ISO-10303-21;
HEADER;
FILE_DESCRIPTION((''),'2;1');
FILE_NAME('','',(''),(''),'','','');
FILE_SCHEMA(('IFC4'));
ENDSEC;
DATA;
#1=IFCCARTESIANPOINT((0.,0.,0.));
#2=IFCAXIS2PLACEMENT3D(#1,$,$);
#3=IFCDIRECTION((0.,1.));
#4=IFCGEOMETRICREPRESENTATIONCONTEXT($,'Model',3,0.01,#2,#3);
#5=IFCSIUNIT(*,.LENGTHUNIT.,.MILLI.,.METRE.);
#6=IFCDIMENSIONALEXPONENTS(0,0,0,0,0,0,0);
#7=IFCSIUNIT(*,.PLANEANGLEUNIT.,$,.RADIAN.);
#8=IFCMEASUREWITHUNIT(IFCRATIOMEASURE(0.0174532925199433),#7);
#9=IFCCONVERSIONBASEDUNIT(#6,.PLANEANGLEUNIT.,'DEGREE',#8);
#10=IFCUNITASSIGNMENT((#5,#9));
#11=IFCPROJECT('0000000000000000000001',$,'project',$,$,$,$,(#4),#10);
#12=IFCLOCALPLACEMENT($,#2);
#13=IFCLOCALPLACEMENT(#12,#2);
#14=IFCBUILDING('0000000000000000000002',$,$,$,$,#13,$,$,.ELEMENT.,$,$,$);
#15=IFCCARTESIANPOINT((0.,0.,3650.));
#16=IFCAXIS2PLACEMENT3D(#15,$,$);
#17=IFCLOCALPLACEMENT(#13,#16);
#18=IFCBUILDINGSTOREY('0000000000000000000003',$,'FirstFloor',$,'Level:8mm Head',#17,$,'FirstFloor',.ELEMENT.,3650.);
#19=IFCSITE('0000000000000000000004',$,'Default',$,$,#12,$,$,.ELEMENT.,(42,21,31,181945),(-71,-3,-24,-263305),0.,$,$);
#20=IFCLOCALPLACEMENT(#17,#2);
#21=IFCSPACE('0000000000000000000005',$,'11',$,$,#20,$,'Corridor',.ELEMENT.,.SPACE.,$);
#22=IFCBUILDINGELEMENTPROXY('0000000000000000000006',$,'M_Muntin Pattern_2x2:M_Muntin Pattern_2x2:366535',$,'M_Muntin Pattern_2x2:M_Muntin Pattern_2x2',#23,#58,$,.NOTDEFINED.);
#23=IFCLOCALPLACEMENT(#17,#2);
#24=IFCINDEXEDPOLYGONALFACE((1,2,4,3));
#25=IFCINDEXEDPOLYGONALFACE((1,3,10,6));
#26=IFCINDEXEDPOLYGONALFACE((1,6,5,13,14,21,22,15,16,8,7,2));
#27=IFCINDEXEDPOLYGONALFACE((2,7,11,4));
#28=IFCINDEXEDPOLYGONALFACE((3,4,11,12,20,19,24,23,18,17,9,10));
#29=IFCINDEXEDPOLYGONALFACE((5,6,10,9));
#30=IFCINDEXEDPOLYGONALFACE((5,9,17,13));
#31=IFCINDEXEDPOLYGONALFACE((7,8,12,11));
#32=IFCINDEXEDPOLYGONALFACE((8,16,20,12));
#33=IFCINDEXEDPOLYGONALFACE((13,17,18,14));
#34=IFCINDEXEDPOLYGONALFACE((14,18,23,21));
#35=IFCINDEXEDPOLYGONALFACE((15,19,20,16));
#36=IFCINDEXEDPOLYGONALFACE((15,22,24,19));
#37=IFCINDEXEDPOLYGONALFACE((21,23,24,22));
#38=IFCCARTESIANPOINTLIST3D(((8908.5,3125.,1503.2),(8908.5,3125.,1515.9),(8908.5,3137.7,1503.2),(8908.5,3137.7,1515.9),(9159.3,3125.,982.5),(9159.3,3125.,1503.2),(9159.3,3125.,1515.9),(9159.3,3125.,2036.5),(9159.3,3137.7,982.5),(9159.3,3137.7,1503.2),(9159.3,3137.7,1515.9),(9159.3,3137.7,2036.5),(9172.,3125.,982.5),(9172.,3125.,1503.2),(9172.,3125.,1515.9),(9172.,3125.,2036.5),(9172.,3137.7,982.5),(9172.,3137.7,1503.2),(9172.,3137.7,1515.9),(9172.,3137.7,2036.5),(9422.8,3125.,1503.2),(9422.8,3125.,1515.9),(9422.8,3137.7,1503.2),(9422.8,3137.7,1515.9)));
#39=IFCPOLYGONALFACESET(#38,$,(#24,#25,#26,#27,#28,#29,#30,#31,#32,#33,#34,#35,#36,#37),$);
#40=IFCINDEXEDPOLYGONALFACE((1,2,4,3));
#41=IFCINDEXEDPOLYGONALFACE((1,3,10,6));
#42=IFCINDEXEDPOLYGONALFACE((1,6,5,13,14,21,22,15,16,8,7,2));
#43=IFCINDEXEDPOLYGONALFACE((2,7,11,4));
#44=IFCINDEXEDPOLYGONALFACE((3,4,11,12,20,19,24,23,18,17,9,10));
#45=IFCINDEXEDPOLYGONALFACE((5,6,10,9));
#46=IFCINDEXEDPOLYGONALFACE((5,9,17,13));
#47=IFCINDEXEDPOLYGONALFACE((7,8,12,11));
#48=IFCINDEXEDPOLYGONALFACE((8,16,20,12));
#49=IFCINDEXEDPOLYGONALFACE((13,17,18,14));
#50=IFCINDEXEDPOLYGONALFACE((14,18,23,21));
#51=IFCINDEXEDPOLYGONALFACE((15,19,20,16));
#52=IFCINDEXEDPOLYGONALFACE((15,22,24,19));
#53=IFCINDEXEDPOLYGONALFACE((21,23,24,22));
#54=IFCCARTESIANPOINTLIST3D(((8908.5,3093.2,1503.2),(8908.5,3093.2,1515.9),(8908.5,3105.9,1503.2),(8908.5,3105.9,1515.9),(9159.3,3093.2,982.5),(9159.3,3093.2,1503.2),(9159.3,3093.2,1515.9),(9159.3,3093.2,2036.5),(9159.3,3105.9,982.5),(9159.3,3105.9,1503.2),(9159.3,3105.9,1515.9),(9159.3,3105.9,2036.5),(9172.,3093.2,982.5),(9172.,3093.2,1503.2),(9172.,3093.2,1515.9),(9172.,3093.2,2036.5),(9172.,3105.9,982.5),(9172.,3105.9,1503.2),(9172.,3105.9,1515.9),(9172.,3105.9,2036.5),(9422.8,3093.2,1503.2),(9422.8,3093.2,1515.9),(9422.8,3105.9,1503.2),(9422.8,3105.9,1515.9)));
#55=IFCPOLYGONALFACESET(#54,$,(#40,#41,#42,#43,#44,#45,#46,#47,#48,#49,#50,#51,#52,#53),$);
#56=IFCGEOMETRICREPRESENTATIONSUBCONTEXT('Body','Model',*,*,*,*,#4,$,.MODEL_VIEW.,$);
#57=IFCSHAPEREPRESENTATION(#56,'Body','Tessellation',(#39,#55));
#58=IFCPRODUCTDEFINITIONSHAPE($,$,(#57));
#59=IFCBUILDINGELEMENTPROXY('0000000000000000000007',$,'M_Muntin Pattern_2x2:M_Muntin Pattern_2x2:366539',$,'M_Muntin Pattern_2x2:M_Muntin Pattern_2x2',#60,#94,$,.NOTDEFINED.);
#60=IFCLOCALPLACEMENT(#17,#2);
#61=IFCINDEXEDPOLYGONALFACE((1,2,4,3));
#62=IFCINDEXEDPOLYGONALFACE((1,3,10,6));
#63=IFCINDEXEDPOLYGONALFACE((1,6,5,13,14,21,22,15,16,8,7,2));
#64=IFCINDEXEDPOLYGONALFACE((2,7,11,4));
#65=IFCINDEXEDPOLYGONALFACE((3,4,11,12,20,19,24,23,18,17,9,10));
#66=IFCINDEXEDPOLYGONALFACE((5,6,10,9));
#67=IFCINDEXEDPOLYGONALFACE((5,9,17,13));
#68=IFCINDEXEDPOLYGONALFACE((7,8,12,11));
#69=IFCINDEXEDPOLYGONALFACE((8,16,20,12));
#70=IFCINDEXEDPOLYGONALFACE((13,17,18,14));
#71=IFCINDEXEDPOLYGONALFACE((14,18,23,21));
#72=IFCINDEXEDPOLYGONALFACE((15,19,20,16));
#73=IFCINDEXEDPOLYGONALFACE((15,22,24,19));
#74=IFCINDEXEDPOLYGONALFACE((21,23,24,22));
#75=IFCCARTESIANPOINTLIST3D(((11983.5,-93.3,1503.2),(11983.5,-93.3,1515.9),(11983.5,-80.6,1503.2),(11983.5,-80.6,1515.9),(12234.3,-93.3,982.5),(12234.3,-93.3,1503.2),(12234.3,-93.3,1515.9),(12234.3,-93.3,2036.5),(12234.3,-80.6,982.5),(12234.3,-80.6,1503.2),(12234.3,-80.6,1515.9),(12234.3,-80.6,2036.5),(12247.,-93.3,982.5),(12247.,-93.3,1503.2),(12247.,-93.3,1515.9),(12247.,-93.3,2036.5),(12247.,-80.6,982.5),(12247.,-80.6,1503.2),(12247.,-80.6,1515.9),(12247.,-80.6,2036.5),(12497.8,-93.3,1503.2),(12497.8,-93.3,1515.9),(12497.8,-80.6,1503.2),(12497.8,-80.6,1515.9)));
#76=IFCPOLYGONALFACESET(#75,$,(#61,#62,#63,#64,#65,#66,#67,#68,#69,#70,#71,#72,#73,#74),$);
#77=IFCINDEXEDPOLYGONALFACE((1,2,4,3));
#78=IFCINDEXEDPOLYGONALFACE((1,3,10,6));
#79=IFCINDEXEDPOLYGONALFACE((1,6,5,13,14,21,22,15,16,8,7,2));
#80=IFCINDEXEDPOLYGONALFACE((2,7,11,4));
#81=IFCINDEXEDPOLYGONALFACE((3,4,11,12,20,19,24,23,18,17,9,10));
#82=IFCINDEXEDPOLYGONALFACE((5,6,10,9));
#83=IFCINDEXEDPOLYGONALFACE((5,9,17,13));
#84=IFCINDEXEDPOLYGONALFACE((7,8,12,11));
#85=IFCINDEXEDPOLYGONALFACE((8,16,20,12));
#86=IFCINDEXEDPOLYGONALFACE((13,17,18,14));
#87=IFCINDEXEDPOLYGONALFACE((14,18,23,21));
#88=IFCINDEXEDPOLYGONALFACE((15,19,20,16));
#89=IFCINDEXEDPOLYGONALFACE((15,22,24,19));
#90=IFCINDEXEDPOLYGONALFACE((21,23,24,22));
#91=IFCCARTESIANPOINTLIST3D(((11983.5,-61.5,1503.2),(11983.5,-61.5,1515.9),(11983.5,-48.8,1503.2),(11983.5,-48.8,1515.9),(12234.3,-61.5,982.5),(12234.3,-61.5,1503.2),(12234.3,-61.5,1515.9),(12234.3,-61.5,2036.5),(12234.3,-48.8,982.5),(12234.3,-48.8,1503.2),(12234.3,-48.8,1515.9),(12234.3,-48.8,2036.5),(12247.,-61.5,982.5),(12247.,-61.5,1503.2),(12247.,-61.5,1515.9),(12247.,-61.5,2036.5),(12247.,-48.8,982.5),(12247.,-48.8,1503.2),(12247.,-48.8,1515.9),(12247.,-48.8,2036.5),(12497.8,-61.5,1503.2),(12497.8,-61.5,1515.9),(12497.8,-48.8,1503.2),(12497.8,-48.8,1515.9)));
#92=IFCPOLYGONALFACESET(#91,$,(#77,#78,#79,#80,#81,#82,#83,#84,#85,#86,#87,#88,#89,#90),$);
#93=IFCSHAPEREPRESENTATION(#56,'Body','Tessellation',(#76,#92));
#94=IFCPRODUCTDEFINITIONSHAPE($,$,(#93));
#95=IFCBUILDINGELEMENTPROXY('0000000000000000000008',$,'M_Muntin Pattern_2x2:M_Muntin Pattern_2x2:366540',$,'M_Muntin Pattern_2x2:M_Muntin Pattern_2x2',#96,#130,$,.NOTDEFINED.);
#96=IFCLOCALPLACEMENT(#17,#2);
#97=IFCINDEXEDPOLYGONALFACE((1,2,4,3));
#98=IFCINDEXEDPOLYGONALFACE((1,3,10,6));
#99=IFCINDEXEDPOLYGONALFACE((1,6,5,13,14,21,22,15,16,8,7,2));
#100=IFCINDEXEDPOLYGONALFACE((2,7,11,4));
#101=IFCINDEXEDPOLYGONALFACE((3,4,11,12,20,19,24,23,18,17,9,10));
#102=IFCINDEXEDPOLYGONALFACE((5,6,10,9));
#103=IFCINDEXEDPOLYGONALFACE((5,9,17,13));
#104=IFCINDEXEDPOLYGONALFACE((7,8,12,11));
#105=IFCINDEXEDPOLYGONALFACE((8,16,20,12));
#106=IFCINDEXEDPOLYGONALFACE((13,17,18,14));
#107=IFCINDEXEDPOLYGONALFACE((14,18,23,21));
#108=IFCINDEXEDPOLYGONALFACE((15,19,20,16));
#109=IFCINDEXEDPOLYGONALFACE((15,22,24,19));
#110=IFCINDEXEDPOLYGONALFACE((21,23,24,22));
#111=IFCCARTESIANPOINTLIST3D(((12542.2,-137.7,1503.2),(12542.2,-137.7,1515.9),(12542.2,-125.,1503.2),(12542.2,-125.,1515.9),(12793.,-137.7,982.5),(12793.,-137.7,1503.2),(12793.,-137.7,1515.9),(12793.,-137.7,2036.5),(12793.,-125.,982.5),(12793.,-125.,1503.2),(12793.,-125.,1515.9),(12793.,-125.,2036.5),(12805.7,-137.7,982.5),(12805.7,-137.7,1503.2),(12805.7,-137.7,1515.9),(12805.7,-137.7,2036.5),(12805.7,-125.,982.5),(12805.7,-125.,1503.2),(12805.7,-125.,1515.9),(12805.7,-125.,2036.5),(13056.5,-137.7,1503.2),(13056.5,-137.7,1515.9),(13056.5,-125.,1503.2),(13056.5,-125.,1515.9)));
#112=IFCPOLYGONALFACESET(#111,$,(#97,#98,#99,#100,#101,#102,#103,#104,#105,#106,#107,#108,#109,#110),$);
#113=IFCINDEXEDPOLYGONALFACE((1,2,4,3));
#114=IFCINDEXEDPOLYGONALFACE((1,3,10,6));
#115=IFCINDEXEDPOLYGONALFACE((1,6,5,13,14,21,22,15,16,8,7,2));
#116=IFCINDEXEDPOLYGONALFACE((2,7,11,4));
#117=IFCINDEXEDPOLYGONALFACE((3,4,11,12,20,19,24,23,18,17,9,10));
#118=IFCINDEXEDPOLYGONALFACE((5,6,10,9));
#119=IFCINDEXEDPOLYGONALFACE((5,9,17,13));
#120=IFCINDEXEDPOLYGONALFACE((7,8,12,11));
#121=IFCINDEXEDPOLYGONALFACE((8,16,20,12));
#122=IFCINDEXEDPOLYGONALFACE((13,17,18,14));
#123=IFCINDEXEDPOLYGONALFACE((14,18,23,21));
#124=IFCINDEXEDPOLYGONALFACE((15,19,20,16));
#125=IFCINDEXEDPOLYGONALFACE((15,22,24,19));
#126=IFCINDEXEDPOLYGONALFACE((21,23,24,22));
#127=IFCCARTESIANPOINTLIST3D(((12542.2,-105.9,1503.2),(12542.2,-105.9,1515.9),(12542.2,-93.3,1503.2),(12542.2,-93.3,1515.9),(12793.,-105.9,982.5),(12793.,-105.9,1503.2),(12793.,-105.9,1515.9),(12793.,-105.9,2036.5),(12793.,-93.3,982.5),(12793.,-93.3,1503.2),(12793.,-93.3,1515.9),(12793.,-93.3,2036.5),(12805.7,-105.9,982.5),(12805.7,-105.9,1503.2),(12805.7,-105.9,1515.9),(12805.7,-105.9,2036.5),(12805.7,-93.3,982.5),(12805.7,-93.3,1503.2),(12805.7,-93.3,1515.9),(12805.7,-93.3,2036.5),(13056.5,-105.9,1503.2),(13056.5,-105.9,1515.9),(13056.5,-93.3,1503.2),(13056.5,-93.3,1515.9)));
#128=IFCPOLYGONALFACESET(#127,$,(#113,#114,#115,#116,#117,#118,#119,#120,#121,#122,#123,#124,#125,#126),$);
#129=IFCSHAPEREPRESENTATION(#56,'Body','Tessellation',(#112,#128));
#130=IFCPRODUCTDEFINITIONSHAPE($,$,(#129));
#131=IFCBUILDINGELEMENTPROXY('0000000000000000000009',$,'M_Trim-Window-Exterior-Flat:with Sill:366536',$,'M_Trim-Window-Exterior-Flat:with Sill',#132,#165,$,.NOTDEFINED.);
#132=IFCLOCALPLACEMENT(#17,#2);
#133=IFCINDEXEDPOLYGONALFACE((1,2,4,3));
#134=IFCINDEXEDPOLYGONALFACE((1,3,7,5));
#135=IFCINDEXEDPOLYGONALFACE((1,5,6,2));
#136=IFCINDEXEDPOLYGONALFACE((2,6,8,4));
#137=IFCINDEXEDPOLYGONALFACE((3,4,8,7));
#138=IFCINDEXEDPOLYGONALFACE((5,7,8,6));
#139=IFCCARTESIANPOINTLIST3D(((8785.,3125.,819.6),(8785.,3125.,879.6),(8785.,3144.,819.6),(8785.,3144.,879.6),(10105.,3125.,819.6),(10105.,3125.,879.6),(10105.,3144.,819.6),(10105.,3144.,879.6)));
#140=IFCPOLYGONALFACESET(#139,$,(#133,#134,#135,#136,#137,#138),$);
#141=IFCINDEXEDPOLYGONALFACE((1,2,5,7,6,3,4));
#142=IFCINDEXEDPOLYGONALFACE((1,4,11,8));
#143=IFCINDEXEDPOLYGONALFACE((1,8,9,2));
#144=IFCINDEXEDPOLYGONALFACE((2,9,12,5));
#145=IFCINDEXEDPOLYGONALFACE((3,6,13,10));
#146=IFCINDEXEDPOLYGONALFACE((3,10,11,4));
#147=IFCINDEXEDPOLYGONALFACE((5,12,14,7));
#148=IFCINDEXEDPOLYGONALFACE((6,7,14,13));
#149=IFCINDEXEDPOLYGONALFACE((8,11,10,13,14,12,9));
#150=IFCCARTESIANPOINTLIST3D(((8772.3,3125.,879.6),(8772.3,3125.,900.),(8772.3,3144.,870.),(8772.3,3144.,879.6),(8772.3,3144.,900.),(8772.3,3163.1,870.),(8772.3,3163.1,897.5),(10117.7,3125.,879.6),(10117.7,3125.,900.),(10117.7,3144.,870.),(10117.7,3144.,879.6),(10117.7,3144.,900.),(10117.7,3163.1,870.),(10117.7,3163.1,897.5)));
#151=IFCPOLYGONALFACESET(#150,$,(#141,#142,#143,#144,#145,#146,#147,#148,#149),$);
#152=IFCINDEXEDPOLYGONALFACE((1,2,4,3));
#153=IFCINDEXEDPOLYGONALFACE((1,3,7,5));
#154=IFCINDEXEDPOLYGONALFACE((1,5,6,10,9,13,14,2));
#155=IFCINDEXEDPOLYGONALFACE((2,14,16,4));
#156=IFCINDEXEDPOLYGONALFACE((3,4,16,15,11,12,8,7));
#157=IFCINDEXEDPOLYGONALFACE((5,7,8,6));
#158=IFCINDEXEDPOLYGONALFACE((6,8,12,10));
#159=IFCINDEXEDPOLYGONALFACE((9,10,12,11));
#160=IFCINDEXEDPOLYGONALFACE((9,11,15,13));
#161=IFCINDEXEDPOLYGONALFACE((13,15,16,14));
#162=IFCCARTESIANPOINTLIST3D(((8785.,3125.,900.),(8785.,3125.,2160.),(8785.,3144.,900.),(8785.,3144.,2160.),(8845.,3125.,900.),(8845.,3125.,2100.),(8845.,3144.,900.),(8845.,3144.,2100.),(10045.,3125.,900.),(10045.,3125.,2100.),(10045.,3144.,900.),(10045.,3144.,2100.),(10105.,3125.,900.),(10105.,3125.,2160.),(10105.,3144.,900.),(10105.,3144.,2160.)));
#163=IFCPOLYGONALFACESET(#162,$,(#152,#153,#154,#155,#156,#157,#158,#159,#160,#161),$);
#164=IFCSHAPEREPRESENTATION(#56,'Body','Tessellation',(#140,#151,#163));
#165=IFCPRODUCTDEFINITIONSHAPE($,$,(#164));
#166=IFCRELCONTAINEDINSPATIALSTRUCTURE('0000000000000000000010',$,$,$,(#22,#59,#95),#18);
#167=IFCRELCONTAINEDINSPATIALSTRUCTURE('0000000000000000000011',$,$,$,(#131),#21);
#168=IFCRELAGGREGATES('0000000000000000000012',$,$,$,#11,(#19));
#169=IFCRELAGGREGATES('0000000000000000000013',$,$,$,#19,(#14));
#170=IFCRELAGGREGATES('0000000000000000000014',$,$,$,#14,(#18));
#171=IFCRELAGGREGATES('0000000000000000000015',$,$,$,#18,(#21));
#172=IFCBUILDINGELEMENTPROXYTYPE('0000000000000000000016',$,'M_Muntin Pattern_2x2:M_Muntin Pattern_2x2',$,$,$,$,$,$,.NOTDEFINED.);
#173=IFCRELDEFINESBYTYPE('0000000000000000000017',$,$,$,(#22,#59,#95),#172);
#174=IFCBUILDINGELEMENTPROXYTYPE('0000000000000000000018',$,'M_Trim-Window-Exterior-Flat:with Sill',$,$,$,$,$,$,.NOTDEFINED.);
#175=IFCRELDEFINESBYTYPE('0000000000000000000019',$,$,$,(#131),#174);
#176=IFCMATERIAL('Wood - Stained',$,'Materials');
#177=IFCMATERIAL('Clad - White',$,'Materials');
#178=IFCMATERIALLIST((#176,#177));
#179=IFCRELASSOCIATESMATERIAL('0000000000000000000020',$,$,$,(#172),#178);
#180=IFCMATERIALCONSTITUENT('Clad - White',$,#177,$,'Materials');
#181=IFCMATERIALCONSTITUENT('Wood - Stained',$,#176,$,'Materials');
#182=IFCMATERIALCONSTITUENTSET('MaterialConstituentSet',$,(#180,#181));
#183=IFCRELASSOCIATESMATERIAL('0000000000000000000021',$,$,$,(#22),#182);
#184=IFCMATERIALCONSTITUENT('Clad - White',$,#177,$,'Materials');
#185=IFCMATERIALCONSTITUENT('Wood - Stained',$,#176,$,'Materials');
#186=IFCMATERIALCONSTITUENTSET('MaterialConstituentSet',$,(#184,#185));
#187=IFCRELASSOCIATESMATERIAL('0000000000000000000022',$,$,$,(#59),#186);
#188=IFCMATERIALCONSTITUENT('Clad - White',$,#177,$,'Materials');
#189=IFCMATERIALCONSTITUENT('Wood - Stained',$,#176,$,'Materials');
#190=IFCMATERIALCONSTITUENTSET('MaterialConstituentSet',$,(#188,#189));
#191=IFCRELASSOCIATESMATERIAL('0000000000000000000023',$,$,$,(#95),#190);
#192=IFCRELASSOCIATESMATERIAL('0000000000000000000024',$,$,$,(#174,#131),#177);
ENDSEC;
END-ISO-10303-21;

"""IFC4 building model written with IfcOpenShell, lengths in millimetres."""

from ifc_helpers import new_model, entity, si_unit, converted_unit, direction, frame, frame_2d, origin, place, context, subcontext, project, spatial, polyline, rectangle, outline, extrude, source, transform, mapped, material, material_list, constituent, constituent_set, type_object, type_shapes, element, save


model = new_model("IFC4")

# Units and contexts
model_context = context("Model", 3, precision=0.01, world=origin(), true_north=direction((0.0, 1.0)))
body_context = subcontext(model_context, "Body", "Model", "MODEL_VIEW")
ifc_project = project(units=[si_unit("LENGTHUNIT", "METRE", prefix="MILLI"), converted_unit("PLANEANGLEUNIT", "DEGREE", entity("IfcRatioMeasure", 0.0174532925199433), si_unit("PLANEANGLEUNIT", "RADIAN"), dimensions=[0, 0, 0, 0, 0, 0, 0])], contexts=[model_context])

# Site, building, storey
site_placement = place(None, origin())
site = spatial("IfcSite", under=ifc_project, at=site_placement, Name="Default", CompositionType="ELEMENT", RefLatitude=(42, 21, 31, 181945), RefLongitude=(-71, -3, -24, -263305), RefElevation=0.0)
building_placement = place(site_placement, origin())
building = spatial("IfcBuilding", under=site, at=building_placement, CompositionType="ELEMENT")
storey_placement = place(building_placement, frame((0.0, 0.0, 3650.0)))
storey = spatial("IfcBuildingStorey", under=building, at=storey_placement, Name="FirstFloor", ObjectType="Level:8mm Head", LongName="FirstFloor", CompositionType="ELEMENT", Elevation=3650.0)

# Building element proxies
ifc_material_1 = material(Name="Clad - White", Category="Materials")
ifc_material_2 = material(Name="Wood - Stained", Category="Materials")
ifc_material_list_1 = material_list([ifc_material_2, ifc_material_1])
building_element_proxy_type_1 = type_object("IfcBuildingElementProxyType", Name="M_Muntin Pattern_2x2:M_Muntin Pattern_2x2", PredefinedType="NOTDEFINED", material=ifc_material_list_1)
shared_shape_1 = source(origin(), body_context, "Body", "SweptSolid", [
    extrude(outline(polyline([(6.4, -6.4), (527.0, -6.4), (527.0, 6.3), (6.4, 6.3), (6.4, 257.1), (-6.3, 257.1), (-6.3, 6.3), (-527.0, 6.3), (-527.0, -6.4), (-6.3, -6.4), (-6.3, -257.1), (6.4, -257.1), (6.4, -6.4)])), frame((0.0, 9.5, 527.0), z_axis=(0.0, 1.0, 0.0), x_axis=(0.0, 0.0, 1.0)), (0.0, 0.0, 1.0), 12.7),
    extrude(outline(polyline([(6.4, -6.4), (527.0, -6.4), (527.0, 6.3), (6.4, 6.3), (6.4, 257.1), (-6.3, 257.1), (-6.3, 6.3), (-527.0, 6.3), (-527.0, -6.4), (-6.3, -6.4), (-6.3, -257.1), (6.4, -257.1), (6.4, -6.4)])), frame((0.0, -22.2, 527.0), z_axis=(0.0, 1.0, 0.0), x_axis=(0.0, 0.0, 1.0)), (0.0, 0.0, 1.0), 12.7),
])
type_shapes(building_element_proxy_type_1, [shared_shape_1])
ifc_constituent_1 = constituent(ifc_material_1, Name="Clad - White", Category="Materials")
ifc_constituent_2 = constituent(ifc_material_2, Name="Wood - Stained", Category="Materials")
ifc_constituent_set_1 = constituent_set(constituents=[ifc_constituent_1, ifc_constituent_2], Name="MaterialConstituentSet")
proxy_1_placement = place(storey_placement, frame((9165.6, 3115.5, 982.5)))
element("IfcBuildingElementProxy", 1, at=proxy_1_placement, inside=storey, type_object=building_element_proxy_type_1, material=ifc_constituent_set_1, Name="M_Muntin Pattern_2x2:M_Muntin Pattern_2x2:366535", ObjectType="M_Muntin Pattern_2x2:M_Muntin Pattern_2x2", PredefinedType="NOTDEFINED", context=body_context, shape_type="MappedRepresentation", body=[
    mapped(shared_shape_1, transform((0.0, 0.0, 0.0), scale=1.0)),
])
ifc_constituent_3 = constituent(ifc_material_1, Name="Clad - White", Category="Materials")
ifc_constituent_4 = constituent(ifc_material_2, Name="Wood - Stained", Category="Materials")
ifc_constituent_set_2 = constituent_set(constituents=[ifc_constituent_3, ifc_constituent_4], Name="MaterialConstituentSet")
proxy_2_placement = place(storey_placement, frame((12240.6, -71.0, 982.5), z_axis=(0.0, 0.0, 1.0), x_axis=(-1.0, 0.0, 0.0)))
element("IfcBuildingElementProxy", 2, at=proxy_2_placement, inside=storey, type_object=building_element_proxy_type_1, material=ifc_constituent_set_2, Name="M_Muntin Pattern_2x2:M_Muntin Pattern_2x2:366539", ObjectType="M_Muntin Pattern_2x2:M_Muntin Pattern_2x2", PredefinedType="NOTDEFINED", context=body_context, shape_type="MappedRepresentation", body=[
    mapped(shared_shape_1, transform((0.0, 0.0, 0.0), scale=1.0)),
])
ifc_constituent_5 = constituent(ifc_material_1, Name="Clad - White", Category="Materials")
ifc_constituent_6 = constituent(ifc_material_2, Name="Wood - Stained", Category="Materials")
ifc_constituent_set_3 = constituent_set(constituents=[ifc_constituent_5, ifc_constituent_6], Name="MaterialConstituentSet")
proxy_3_placement = place(storey_placement, frame((12799.4, -115.5, 982.5), z_axis=(0.0, 0.0, 1.0), x_axis=(-1.0, 0.0, 0.0)))
element("IfcBuildingElementProxy", 3, at=proxy_3_placement, inside=storey, type_object=building_element_proxy_type_1, material=ifc_constituent_set_3, Name="M_Muntin Pattern_2x2:M_Muntin Pattern_2x2:366540", ObjectType="M_Muntin Pattern_2x2:M_Muntin Pattern_2x2", PredefinedType="NOTDEFINED", context=body_context, shape_type="MappedRepresentation", body=[
    mapped(shared_shape_1, transform((0.0, 0.0, 0.0), scale=1.0)),
])

# Shared definitions
space_1_placement = place(storey_placement, origin())
space_1 = spatial("IfcSpace", under=storey, at=space_1_placement, Name="11", LongName="Corridor", CompositionType="ELEMENT", PredefinedType="SPACE")

# Building element proxy
building_element_proxy_type_2 = type_object("IfcBuildingElementProxyType", Name="M_Trim-Window-Exterior-Flat:with Sill", PredefinedType="NOTDEFINED", material=ifc_material_1)
shared_shape_2 = source(origin(), body_context, "Body", "SweptSolid", [
    extrude(rectangle(XDim=1320.0, YDim=60.0, at=frame_2d((0.0, 0.0), x_axis=(1.0, 0.0))), frame((0.0, -1250.4, 0.0), z_axis=(0.0, 0.0, 1.0), x_axis=(-1.0, 0.0, 0.0)), (0.0, 0.0, 1.0), 19.1),
    extrude(outline(polyline([(-19.0, -15.2), (0.0, -15.2), (0.0, -5.7), (19.0, -5.7), (19.0, 14.8), (0.0, 14.8), (-19.0, 12.3), (-19.0, -15.2)])), frame((-672.7, -1214.8, 19.0), z_axis=(1.0, 0.0, 0.0), x_axis=(0.0, 0.0, -1.0)), (0.0, 0.0, 1.0), 1345.4),
    extrude(outline(polyline([(-645.0, -660.0), (615.0, -660.0), (615.0, -600.0), (-585.0, -600.0), (-585.0, 600.0), (615.0, 600.0), (615.0, 660.0), (-645.0, 660.0), (-645.0, -660.0)])), frame((0.0, -585.0, 0.0), z_axis=(0.0, 0.0, 1.0), x_axis=(0.0, -1.0, 0.0)), (0.0, 0.0, 1.0), 19.1),
])
type_shapes(building_element_proxy_type_2, [shared_shape_2])
proxy_4_placement = place(space_1_placement, frame((9445.0, 3125.0, 2100.0), z_axis=(0.0, 1.0, 0.0), x_axis=(-1.0, 0.0, 0.0)))
element("IfcBuildingElementProxy", 4, at=proxy_4_placement, inside=space_1, type_object=building_element_proxy_type_2, material=ifc_material_1, Name="M_Trim-Window-Exterior-Flat:with Sill:366536", ObjectType="M_Trim-Window-Exterior-Flat:with Sill", PredefinedType="NOTDEFINED", context=body_context, shape_type="MappedRepresentation", body=[
    mapped(shared_shape_2, transform((0.0, 0.0, 0.0), scale=1.0)),
])

save(model, "model.ifc")
